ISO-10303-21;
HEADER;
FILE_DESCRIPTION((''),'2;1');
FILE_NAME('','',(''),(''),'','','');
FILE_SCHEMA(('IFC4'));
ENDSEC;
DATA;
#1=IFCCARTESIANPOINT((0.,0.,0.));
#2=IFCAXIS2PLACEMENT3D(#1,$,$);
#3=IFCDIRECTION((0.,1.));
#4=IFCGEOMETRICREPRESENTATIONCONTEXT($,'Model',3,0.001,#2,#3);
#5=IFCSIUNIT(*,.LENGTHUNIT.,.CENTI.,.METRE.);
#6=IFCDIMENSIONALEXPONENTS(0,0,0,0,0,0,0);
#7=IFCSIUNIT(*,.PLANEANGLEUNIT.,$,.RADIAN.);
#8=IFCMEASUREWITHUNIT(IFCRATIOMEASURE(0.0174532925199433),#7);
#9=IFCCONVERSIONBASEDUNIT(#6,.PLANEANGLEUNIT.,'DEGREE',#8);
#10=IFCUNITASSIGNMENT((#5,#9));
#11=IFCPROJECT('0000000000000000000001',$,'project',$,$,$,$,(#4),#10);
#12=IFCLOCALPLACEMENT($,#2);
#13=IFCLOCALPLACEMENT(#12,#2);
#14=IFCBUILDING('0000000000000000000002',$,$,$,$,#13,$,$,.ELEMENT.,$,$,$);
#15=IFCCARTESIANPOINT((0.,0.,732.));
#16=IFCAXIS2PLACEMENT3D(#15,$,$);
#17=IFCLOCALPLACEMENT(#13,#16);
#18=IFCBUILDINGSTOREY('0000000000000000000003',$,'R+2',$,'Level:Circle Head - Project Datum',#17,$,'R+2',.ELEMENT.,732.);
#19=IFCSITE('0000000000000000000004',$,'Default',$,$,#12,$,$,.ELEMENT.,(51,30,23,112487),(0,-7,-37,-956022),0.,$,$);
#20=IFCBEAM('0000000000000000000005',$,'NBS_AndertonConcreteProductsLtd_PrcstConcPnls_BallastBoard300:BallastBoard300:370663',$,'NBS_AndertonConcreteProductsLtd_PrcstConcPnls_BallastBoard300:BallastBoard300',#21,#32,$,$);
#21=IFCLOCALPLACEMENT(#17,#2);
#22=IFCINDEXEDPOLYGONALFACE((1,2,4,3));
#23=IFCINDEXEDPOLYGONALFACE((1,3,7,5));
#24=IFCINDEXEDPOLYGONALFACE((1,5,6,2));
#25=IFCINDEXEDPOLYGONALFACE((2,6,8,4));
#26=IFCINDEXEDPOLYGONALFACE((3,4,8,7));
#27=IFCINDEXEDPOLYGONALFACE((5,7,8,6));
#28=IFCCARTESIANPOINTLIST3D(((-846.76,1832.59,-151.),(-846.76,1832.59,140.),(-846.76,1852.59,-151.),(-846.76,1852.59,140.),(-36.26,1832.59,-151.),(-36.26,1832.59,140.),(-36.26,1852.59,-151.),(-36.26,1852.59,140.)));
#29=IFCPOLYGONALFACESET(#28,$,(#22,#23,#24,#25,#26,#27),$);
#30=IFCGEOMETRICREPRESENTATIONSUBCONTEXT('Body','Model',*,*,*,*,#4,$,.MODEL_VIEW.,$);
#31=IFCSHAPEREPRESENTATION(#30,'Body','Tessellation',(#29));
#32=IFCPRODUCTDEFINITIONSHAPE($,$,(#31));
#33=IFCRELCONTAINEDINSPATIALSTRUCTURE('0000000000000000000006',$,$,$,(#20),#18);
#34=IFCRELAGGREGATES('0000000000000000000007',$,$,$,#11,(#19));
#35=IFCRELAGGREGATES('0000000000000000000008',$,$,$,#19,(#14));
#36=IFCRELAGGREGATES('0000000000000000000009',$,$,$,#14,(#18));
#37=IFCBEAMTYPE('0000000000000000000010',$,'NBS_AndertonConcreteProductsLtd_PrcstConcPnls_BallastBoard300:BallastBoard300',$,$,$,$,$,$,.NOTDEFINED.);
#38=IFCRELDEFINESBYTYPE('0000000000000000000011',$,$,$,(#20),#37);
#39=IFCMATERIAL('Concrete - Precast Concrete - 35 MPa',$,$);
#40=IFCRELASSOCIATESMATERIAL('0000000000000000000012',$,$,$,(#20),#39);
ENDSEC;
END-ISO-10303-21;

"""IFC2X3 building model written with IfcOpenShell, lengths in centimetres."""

from ifc_helpers import new_model, entity, si_unit, converted_unit, direction, frame, frame_2d, origin, place, context, subcontext, project, spatial, rectangle, extrude, material, type_object, element, save


model = new_model("IFC2X3")

# Units and contexts
model_context = context("Model", 3, precision=0.001, world=origin(), true_north=direction((0.0, 1.0)))
body_context = subcontext(model_context, "Body", "Model", "MODEL_VIEW")
ifc_project = project(units=[si_unit("LENGTHUNIT", "METRE", prefix="CENTI"), converted_unit("PLANEANGLEUNIT", "DEGREE", entity("IfcRatioMeasure", 0.0174532925199433), si_unit("PLANEANGLEUNIT", "RADIAN"), dimensions=[0, 0, 0, 0, 0, 0, 0])], contexts=[model_context])

# Site, building, storey
site_placement = place(None, origin())
site = spatial("IfcSite", under=ifc_project, at=site_placement, Name="Default", CompositionType="ELEMENT", RefLatitude=(51, 30, 23, 112487), RefLongitude=(0, -7, -37, -956022), RefElevation=0.0)
building_placement = place(site_placement, origin())
building = spatial("IfcBuilding", under=site, at=building_placement, CompositionType="ELEMENT")
storey_placement = place(building_placement, frame((0.0, 0.0, 732.0)))
storey = spatial("IfcBuildingStorey", under=building, at=storey_placement, Name="R+2", ObjectType="Level:Circle Head - Project Datum", LongName="R+2", CompositionType="ELEMENT", Elevation=732.0)

# Beam
ifc_material = material(Name="Concrete - Precast Concrete - 35 MPa")
beam_type = type_object("IfcBeamType", Name="NBS_AndertonConcreteProductsLtd_PrcstConcPnls_BallastBoard300:BallastBoard300", PredefinedType="NOTDEFINED")
beam_placement = place(storey_placement, origin())
element("IfcBeam", 1, at=beam_placement, inside=storey, type_object=beam_type, material=ifc_material, Name="NBS_AndertonConcreteProductsLtd_PrcstConcPnls_BallastBoard300:BallastBoard300:370663", ObjectType="NBS_AndertonConcreteProductsLtd_PrcstConcPnls_BallastBoard300:BallastBoard300", context=body_context, shape_type="SweptSolid", body=[
    extrude(rectangle(XDim=291.0, YDim=20.0, at=frame_2d((0.0, 0.0), x_axis=(0.0, 1.0))), frame((-846.76, 1842.59, -5.5), z_axis=(1.0, 0.0, 0.0), x_axis=(0.0, 1.0, 0.0)), (0.0, 0.0, 1.0), 810.5),
])

save(model, "model.ifc")
